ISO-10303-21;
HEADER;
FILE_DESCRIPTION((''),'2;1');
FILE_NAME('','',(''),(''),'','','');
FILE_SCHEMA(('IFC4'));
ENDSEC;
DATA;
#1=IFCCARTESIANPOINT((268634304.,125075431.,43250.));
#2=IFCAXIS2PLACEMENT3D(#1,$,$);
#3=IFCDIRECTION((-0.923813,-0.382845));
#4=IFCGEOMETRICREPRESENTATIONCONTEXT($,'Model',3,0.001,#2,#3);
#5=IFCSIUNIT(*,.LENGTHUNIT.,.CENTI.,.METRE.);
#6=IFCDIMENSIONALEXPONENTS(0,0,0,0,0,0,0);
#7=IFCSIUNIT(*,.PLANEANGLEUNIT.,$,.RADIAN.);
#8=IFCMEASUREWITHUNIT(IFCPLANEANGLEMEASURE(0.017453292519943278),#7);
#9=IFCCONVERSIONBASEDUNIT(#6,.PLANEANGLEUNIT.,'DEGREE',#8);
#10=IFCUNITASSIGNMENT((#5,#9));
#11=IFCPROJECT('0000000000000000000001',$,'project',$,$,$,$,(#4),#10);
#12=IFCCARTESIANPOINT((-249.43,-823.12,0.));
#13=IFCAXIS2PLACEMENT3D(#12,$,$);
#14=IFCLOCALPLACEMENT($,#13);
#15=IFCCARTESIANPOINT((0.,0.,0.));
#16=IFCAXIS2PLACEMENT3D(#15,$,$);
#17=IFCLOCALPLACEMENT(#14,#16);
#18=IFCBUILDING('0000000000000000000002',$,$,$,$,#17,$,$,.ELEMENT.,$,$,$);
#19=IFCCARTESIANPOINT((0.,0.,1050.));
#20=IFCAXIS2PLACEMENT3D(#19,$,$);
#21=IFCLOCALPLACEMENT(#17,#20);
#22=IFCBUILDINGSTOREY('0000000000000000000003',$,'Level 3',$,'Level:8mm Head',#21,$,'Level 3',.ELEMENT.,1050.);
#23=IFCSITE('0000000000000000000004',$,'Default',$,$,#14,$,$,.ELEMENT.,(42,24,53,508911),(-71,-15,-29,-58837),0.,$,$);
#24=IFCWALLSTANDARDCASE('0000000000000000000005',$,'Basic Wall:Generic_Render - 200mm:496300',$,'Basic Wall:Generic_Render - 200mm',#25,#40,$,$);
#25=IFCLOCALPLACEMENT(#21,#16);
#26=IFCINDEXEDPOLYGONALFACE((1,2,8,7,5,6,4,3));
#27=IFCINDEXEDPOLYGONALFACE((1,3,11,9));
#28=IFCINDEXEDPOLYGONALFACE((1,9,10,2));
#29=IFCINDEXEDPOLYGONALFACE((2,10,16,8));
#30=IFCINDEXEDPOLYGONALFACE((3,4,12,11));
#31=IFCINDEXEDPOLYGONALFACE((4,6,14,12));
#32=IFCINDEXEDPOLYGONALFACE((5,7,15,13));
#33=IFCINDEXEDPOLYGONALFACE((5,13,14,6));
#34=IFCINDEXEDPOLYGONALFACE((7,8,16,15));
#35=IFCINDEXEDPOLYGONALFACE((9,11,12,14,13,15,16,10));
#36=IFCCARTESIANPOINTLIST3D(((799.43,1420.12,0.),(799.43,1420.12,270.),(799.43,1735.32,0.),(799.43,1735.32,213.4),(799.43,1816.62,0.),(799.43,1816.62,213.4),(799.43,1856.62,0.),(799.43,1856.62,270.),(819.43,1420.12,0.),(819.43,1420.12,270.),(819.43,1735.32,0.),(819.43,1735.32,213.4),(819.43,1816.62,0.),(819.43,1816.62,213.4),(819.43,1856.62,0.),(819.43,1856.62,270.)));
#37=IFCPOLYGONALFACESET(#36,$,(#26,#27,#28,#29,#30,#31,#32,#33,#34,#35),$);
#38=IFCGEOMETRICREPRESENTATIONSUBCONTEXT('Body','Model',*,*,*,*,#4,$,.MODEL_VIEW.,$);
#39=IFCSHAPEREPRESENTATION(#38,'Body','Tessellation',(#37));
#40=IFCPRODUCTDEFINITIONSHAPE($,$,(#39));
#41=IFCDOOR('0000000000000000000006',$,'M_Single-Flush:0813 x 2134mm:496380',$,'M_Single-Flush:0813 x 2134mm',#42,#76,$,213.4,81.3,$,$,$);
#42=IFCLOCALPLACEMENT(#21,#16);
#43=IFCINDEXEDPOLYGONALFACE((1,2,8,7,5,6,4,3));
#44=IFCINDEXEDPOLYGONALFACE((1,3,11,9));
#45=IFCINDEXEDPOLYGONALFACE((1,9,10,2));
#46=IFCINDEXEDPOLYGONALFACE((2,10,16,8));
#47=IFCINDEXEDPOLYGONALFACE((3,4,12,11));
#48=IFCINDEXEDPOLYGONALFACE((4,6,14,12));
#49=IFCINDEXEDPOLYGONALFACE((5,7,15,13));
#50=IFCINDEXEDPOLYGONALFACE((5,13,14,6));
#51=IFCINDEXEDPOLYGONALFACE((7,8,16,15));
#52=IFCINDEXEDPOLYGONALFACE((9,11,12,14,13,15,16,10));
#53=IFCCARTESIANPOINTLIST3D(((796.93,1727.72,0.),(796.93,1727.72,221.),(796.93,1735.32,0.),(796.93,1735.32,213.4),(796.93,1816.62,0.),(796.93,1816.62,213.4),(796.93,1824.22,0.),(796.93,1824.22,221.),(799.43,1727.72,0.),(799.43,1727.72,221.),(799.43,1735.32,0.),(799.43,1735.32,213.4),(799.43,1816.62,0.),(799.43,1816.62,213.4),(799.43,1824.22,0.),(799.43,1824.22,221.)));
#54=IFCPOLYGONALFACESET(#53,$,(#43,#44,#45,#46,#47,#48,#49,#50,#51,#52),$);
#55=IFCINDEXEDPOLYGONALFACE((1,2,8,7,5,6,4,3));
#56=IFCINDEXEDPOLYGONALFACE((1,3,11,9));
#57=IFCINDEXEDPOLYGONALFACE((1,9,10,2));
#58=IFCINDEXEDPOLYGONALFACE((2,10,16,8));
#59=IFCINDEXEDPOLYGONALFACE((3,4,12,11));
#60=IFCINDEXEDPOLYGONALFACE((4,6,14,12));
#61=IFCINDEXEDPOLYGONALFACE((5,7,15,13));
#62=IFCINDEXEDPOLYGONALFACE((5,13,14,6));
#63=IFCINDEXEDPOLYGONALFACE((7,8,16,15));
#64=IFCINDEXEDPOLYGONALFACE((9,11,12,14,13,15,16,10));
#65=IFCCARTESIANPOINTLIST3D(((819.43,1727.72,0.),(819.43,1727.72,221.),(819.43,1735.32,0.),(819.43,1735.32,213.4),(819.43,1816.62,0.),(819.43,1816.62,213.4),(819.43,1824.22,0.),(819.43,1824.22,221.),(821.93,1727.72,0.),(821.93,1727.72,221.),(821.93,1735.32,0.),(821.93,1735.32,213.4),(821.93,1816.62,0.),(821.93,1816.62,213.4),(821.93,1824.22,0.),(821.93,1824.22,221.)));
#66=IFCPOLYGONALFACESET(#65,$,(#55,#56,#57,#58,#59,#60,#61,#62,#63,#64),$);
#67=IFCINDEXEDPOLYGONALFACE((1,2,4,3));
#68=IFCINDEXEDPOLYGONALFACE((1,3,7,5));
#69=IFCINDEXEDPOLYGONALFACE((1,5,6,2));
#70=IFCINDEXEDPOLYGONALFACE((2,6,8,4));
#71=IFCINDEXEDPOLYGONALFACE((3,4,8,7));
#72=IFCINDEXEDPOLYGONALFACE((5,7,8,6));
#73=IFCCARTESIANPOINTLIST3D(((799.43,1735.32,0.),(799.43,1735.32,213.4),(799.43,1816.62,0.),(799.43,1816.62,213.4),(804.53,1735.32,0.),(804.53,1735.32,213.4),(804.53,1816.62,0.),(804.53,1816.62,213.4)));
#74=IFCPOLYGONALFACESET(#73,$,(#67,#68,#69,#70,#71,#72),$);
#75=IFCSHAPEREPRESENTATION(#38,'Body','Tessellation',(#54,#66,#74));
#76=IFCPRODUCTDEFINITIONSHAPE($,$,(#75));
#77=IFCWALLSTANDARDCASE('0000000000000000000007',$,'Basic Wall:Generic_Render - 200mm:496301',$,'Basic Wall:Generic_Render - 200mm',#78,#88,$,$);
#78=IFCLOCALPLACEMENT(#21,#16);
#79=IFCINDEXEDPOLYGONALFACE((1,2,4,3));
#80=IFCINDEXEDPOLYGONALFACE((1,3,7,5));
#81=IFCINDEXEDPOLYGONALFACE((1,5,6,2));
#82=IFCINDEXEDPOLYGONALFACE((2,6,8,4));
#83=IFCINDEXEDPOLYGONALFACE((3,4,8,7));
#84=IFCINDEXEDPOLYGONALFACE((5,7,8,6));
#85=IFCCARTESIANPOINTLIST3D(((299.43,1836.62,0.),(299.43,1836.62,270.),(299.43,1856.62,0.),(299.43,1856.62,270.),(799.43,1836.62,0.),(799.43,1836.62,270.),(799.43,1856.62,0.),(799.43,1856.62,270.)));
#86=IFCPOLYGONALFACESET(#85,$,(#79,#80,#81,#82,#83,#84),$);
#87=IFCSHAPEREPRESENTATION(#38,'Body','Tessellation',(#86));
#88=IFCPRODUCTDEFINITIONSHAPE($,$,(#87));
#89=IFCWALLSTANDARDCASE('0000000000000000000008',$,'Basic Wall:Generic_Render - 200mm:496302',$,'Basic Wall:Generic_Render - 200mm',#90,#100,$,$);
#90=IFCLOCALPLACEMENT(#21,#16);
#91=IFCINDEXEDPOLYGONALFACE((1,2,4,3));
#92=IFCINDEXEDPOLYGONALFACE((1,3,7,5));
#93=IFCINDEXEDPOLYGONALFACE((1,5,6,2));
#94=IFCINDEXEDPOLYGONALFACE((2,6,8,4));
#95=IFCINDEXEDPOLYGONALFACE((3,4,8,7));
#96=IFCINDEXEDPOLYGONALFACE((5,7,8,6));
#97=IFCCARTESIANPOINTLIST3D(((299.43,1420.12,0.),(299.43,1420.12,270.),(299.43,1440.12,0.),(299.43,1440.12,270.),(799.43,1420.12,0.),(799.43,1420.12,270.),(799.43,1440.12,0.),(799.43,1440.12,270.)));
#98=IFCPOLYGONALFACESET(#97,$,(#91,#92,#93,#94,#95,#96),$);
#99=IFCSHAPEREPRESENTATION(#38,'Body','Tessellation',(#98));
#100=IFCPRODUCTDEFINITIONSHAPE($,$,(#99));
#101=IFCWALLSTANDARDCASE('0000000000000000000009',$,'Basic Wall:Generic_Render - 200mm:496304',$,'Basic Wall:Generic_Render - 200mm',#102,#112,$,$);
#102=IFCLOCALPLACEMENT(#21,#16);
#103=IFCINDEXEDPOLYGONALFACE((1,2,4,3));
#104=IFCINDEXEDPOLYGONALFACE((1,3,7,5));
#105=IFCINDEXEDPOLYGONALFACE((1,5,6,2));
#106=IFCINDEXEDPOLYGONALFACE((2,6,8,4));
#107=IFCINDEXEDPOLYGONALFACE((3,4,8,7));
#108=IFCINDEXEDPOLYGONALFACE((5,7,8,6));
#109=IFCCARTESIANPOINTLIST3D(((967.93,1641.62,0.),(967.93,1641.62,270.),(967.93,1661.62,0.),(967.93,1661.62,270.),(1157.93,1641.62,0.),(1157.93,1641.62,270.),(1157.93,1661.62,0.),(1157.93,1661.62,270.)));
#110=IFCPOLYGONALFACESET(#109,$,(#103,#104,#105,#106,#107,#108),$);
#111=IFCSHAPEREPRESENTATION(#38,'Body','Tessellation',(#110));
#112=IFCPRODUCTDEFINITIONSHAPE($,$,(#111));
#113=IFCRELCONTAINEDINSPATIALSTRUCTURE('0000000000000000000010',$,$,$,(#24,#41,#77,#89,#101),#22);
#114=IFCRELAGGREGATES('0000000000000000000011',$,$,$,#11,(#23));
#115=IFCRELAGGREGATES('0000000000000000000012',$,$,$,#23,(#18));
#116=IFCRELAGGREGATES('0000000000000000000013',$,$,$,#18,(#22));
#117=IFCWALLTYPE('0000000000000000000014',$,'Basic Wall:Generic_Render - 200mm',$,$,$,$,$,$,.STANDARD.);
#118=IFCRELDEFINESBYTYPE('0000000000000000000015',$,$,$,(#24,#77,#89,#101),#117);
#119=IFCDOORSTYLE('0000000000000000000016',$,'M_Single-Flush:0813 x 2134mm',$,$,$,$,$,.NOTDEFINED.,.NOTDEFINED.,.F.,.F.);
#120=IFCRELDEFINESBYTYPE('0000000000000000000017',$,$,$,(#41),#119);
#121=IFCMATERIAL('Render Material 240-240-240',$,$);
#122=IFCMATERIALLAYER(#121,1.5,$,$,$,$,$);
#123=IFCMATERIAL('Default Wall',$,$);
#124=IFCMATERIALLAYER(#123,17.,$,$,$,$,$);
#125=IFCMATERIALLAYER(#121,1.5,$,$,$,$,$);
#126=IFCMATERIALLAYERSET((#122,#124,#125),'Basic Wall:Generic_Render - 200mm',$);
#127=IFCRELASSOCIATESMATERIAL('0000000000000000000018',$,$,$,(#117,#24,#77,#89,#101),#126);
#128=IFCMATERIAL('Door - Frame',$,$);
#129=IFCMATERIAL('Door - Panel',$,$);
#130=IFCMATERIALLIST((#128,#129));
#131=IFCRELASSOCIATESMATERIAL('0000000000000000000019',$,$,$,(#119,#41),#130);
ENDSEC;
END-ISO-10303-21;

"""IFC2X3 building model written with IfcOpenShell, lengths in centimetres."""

from ifc_helpers import new_model, entity, si_unit, converted_unit, direction, frame, frame_2d, origin, place, context, subcontext, project, spatial, polyline, rectangle, outline, extrude, source, transform, mapped, material, material_list, layer, layer_set, layer_usage, type_object, type_shapes, element, fill, save


model = new_model("IFC2X3")

# Units and contexts
model_context = context("Model", 3, precision=0.001, world=frame((268634304.0, 125075431.0, 43250.0)), true_north=direction((-0.923813, -0.382845)))
body_context = subcontext(model_context, "Body", "Model", "MODEL_VIEW")
ifc_project = project(units=[si_unit("LENGTHUNIT", "METRE", prefix="CENTI"), converted_unit("PLANEANGLEUNIT", "DEGREE", entity("IfcPlaneAngleMeasure", 0.017453292519943278), si_unit("PLANEANGLEUNIT", "RADIAN"), dimensions=[0, 0, 0, 0, 0, 0, 0])], contexts=[model_context])

# Site, building, storey
site_placement = place(None, frame((-249.43, -823.12, 0.0)))
site = spatial("IfcSite", under=ifc_project, at=site_placement, Name="Default", CompositionType="ELEMENT", RefLatitude=(42, 24, 53, 508911), RefLongitude=(-71, -15, -29, -58837), RefElevation=0.0)
building_placement = place(site_placement, origin())
building = spatial("IfcBuilding", under=site, at=building_placement, CompositionType="ELEMENT")
storey_placement = place(building_placement, frame((0.0, 0.0, 1050.0)))
storey = spatial("IfcBuildingStorey", under=building, at=storey_placement, Name="Level 3", ObjectType="Level:8mm Head", LongName="Level 3", CompositionType="ELEMENT", Elevation=1050.0)

# Shared definitions
ifc_material_1 = material(Name="Render Material 240-240-240")

# Wall, opening, door
ifc_layer_1 = layer(ifc_material_1, 1.5)
ifc_material_2 = material(Name="Default Wall")
ifc_layer_2 = layer(ifc_material_2, 17.0)
ifc_layer_3 = layer(ifc_material_1, 1.5)
ifc_layer_set_1 = layer_set([ifc_layer_1, ifc_layer_2, ifc_layer_3], Name="Basic Wall:Generic_Render - 200mm")
wall_type_1 = type_object("IfcWallType", Name="Basic Wall:Generic_Render - 200mm", PredefinedType="STANDARD", material=ifc_layer_set_1)
ifc_material_3 = material(Name="Door - Frame")
ifc_material_4 = material(Name="Door - Panel")
ifc_material_list = material_list([ifc_material_3, ifc_material_4])
ifc_layer_usage_1 = layer_usage(ifc_layer_set_1, "AXIS2", "NEGATIVE", 10.0)
wall_1_placement = place(storey_placement, frame((809.43, 1856.62, 0.0), z_axis=(0.0, 0.0, 1.0), x_axis=(0.0, -1.0, 0.0)))
wall_1 = element("IfcWallStandardCase", 1, at=wall_1_placement, inside=storey, type_object=wall_type_1, material=ifc_layer_usage_1, Name="Basic Wall:Generic_Render - 200mm:496300", ObjectType="Basic Wall:Generic_Render - 200mm", context=body_context, shape_type="SweptSolid", body=[
    extrude(rectangle(XDim=436.5, YDim=20.0, at=frame_2d((218.25, 0.0), x_axis=(-1.0, 0.0))), origin(), (0.0, 0.0, 1.0), 270.0),
])
opening_1_placement = place(wall_1_placement, frame((121.3, 10.0, 0.0)))
opening_1 = element("IfcOpeningElement", 2, at=opening_1_placement, cuts=wall_1, ObjectType="Opening", context=body_context, shape_type="SweptSolid", body=[
    extrude(rectangle(XDim=81.3, YDim=213.4, at=frame_2d((106.7, 40.65), x_axis=(0.0, 1.0))), frame((0.0, 0.0, 0.0), z_axis=(0.0, -1.0, 0.0), x_axis=(0.0, 0.0, 1.0)), (0.0, 0.0, 1.0), 20.0),
])
door_style_1 = type_object("IfcDoorStyle", Name="M_Single-Flush:0813 x 2134mm", ConstructionType="NOTDEFINED", OperationType="NOTDEFINED", ParameterTakesPrecedence=False, Sizeable=False, material=ifc_material_list)
shared_shape_1 = source(origin(), body_context, "Body", "SweptSolid", [
    extrude(outline(polyline([(-48.25, -112.4), (48.25, -112.4), (48.25, 108.6), (40.65, 108.6), (40.65, -104.8), (-40.65, -104.8), (-40.65, 108.6), (-48.25, 108.6), (-48.25, -112.4)])), frame((40.65, 20.0, 108.6), z_axis=(0.0, 1.0, 0.0), x_axis=(1.0, 0.0, 0.0)), (0.0, 0.0, 1.0), 2.5),
    extrude(outline(polyline([(-112.4, -48.25), (108.6, -48.25), (108.6, -40.65), (-104.8, -40.65), (-104.8, 40.65), (108.6, 40.65), (108.6, 48.25), (-112.4, 48.25), (-112.4, -48.25)])), frame((40.65, -2.5, 108.6), z_axis=(0.0, 1.0, 0.0), x_axis=(0.0, 0.0, -1.0)), (0.0, 0.0, 1.0), 2.5),
    extrude(rectangle(XDim=5.1, YDim=81.3, at=frame_2d((0.0, 0.0), x_axis=(1.0, 0.0))), frame((40.65, 17.45, 0.0), z_axis=(0.0, 0.0, 1.0), x_axis=(0.0, 1.0, 0.0)), (0.0, 0.0, 1.0), 213.4),
])
type_shapes(door_style_1, [shared_shape_1])
door_1_placement = place(opening_1_placement, frame((0.0, 0.0, 0.0), z_axis=(0.0, 0.0, 1.0), x_axis=(-1.0, 0.0, 0.0)))
door_1 = element("IfcDoor", 3, at=door_1_placement, inside=storey, type_object=door_style_1, material=ifc_material_list, Name="M_Single-Flush:0813 x 2134mm:496380", ObjectType="M_Single-Flush:0813 x 2134mm", OverallHeight=213.4, OverallWidth=81.3, context=body_context, shape_type="MappedRepresentation", body=[
    mapped(shared_shape_1, transform((0.0, 0.0, 0.0), scale=1.0)),
])
fill(opening_1, door_1)

# Walls
ifc_layer_usage_2 = layer_usage(ifc_layer_set_1, "AXIS2", "NEGATIVE", 10.0)
wall_2_placement = place(storey_placement, frame((799.43, 1846.62, 0.0), z_axis=(0.0, 0.0, 1.0), x_axis=(-1.0, 0.0, 0.0)))
element("IfcWallStandardCase", 4, at=wall_2_placement, inside=storey, type_object=wall_type_1, material=ifc_layer_usage_2, Name="Basic Wall:Generic_Render - 200mm:496301", ObjectType="Basic Wall:Generic_Render - 200mm", context=body_context, shape_type="SweptSolid", body=[
    extrude(rectangle(XDim=500.0, YDim=20.0, at=frame_2d((250.0, 0.0), x_axis=(-1.0, 0.0))), origin(), (0.0, 0.0, 1.0), 270.0),
])
ifc_layer_usage_3 = layer_usage(ifc_layer_set_1, "AXIS2", "NEGATIVE", 10.0)
wall_3_placement = place(storey_placement, frame((799.43, 1430.12, 0.0), z_axis=(0.0, 0.0, 1.0), x_axis=(-1.0, 0.0, 0.0)))
element("IfcWallStandardCase", 5, at=wall_3_placement, inside=storey, type_object=wall_type_1, material=ifc_layer_usage_3, Name="Basic Wall:Generic_Render - 200mm:496302", ObjectType="Basic Wall:Generic_Render - 200mm", context=body_context, shape_type="SweptSolid", body=[
    extrude(rectangle(XDim=500.0, YDim=20.0, at=frame_2d((250.0, 0.0), x_axis=(-1.0, 0.0))), origin(), (0.0, 0.0, 1.0), 270.0),
])
ifc_layer_usage_4 = layer_usage(ifc_layer_set_1, "AXIS2", "NEGATIVE", 10.0)
wall_4_placement = place(storey_placement, frame((1157.93, 1651.62, 0.0), z_axis=(0.0, 0.0, 1.0), x_axis=(-1.0, 0.0, 0.0)))
element("IfcWallStandardCase", 6, at=wall_4_placement, inside=storey, type_object=wall_type_1, material=ifc_layer_usage_4, Name="Basic Wall:Generic_Render - 200mm:496304", ObjectType="Basic Wall:Generic_Render - 200mm", context=body_context, shape_type="SweptSolid", body=[
    extrude(rectangle(XDim=190.0, YDim=20.0, at=frame_2d((95.0, 0.0), x_axis=(-1.0, 0.0))), origin(), (0.0, 0.0, 1.0), 270.0),
])

save(model, "model.ifc")
